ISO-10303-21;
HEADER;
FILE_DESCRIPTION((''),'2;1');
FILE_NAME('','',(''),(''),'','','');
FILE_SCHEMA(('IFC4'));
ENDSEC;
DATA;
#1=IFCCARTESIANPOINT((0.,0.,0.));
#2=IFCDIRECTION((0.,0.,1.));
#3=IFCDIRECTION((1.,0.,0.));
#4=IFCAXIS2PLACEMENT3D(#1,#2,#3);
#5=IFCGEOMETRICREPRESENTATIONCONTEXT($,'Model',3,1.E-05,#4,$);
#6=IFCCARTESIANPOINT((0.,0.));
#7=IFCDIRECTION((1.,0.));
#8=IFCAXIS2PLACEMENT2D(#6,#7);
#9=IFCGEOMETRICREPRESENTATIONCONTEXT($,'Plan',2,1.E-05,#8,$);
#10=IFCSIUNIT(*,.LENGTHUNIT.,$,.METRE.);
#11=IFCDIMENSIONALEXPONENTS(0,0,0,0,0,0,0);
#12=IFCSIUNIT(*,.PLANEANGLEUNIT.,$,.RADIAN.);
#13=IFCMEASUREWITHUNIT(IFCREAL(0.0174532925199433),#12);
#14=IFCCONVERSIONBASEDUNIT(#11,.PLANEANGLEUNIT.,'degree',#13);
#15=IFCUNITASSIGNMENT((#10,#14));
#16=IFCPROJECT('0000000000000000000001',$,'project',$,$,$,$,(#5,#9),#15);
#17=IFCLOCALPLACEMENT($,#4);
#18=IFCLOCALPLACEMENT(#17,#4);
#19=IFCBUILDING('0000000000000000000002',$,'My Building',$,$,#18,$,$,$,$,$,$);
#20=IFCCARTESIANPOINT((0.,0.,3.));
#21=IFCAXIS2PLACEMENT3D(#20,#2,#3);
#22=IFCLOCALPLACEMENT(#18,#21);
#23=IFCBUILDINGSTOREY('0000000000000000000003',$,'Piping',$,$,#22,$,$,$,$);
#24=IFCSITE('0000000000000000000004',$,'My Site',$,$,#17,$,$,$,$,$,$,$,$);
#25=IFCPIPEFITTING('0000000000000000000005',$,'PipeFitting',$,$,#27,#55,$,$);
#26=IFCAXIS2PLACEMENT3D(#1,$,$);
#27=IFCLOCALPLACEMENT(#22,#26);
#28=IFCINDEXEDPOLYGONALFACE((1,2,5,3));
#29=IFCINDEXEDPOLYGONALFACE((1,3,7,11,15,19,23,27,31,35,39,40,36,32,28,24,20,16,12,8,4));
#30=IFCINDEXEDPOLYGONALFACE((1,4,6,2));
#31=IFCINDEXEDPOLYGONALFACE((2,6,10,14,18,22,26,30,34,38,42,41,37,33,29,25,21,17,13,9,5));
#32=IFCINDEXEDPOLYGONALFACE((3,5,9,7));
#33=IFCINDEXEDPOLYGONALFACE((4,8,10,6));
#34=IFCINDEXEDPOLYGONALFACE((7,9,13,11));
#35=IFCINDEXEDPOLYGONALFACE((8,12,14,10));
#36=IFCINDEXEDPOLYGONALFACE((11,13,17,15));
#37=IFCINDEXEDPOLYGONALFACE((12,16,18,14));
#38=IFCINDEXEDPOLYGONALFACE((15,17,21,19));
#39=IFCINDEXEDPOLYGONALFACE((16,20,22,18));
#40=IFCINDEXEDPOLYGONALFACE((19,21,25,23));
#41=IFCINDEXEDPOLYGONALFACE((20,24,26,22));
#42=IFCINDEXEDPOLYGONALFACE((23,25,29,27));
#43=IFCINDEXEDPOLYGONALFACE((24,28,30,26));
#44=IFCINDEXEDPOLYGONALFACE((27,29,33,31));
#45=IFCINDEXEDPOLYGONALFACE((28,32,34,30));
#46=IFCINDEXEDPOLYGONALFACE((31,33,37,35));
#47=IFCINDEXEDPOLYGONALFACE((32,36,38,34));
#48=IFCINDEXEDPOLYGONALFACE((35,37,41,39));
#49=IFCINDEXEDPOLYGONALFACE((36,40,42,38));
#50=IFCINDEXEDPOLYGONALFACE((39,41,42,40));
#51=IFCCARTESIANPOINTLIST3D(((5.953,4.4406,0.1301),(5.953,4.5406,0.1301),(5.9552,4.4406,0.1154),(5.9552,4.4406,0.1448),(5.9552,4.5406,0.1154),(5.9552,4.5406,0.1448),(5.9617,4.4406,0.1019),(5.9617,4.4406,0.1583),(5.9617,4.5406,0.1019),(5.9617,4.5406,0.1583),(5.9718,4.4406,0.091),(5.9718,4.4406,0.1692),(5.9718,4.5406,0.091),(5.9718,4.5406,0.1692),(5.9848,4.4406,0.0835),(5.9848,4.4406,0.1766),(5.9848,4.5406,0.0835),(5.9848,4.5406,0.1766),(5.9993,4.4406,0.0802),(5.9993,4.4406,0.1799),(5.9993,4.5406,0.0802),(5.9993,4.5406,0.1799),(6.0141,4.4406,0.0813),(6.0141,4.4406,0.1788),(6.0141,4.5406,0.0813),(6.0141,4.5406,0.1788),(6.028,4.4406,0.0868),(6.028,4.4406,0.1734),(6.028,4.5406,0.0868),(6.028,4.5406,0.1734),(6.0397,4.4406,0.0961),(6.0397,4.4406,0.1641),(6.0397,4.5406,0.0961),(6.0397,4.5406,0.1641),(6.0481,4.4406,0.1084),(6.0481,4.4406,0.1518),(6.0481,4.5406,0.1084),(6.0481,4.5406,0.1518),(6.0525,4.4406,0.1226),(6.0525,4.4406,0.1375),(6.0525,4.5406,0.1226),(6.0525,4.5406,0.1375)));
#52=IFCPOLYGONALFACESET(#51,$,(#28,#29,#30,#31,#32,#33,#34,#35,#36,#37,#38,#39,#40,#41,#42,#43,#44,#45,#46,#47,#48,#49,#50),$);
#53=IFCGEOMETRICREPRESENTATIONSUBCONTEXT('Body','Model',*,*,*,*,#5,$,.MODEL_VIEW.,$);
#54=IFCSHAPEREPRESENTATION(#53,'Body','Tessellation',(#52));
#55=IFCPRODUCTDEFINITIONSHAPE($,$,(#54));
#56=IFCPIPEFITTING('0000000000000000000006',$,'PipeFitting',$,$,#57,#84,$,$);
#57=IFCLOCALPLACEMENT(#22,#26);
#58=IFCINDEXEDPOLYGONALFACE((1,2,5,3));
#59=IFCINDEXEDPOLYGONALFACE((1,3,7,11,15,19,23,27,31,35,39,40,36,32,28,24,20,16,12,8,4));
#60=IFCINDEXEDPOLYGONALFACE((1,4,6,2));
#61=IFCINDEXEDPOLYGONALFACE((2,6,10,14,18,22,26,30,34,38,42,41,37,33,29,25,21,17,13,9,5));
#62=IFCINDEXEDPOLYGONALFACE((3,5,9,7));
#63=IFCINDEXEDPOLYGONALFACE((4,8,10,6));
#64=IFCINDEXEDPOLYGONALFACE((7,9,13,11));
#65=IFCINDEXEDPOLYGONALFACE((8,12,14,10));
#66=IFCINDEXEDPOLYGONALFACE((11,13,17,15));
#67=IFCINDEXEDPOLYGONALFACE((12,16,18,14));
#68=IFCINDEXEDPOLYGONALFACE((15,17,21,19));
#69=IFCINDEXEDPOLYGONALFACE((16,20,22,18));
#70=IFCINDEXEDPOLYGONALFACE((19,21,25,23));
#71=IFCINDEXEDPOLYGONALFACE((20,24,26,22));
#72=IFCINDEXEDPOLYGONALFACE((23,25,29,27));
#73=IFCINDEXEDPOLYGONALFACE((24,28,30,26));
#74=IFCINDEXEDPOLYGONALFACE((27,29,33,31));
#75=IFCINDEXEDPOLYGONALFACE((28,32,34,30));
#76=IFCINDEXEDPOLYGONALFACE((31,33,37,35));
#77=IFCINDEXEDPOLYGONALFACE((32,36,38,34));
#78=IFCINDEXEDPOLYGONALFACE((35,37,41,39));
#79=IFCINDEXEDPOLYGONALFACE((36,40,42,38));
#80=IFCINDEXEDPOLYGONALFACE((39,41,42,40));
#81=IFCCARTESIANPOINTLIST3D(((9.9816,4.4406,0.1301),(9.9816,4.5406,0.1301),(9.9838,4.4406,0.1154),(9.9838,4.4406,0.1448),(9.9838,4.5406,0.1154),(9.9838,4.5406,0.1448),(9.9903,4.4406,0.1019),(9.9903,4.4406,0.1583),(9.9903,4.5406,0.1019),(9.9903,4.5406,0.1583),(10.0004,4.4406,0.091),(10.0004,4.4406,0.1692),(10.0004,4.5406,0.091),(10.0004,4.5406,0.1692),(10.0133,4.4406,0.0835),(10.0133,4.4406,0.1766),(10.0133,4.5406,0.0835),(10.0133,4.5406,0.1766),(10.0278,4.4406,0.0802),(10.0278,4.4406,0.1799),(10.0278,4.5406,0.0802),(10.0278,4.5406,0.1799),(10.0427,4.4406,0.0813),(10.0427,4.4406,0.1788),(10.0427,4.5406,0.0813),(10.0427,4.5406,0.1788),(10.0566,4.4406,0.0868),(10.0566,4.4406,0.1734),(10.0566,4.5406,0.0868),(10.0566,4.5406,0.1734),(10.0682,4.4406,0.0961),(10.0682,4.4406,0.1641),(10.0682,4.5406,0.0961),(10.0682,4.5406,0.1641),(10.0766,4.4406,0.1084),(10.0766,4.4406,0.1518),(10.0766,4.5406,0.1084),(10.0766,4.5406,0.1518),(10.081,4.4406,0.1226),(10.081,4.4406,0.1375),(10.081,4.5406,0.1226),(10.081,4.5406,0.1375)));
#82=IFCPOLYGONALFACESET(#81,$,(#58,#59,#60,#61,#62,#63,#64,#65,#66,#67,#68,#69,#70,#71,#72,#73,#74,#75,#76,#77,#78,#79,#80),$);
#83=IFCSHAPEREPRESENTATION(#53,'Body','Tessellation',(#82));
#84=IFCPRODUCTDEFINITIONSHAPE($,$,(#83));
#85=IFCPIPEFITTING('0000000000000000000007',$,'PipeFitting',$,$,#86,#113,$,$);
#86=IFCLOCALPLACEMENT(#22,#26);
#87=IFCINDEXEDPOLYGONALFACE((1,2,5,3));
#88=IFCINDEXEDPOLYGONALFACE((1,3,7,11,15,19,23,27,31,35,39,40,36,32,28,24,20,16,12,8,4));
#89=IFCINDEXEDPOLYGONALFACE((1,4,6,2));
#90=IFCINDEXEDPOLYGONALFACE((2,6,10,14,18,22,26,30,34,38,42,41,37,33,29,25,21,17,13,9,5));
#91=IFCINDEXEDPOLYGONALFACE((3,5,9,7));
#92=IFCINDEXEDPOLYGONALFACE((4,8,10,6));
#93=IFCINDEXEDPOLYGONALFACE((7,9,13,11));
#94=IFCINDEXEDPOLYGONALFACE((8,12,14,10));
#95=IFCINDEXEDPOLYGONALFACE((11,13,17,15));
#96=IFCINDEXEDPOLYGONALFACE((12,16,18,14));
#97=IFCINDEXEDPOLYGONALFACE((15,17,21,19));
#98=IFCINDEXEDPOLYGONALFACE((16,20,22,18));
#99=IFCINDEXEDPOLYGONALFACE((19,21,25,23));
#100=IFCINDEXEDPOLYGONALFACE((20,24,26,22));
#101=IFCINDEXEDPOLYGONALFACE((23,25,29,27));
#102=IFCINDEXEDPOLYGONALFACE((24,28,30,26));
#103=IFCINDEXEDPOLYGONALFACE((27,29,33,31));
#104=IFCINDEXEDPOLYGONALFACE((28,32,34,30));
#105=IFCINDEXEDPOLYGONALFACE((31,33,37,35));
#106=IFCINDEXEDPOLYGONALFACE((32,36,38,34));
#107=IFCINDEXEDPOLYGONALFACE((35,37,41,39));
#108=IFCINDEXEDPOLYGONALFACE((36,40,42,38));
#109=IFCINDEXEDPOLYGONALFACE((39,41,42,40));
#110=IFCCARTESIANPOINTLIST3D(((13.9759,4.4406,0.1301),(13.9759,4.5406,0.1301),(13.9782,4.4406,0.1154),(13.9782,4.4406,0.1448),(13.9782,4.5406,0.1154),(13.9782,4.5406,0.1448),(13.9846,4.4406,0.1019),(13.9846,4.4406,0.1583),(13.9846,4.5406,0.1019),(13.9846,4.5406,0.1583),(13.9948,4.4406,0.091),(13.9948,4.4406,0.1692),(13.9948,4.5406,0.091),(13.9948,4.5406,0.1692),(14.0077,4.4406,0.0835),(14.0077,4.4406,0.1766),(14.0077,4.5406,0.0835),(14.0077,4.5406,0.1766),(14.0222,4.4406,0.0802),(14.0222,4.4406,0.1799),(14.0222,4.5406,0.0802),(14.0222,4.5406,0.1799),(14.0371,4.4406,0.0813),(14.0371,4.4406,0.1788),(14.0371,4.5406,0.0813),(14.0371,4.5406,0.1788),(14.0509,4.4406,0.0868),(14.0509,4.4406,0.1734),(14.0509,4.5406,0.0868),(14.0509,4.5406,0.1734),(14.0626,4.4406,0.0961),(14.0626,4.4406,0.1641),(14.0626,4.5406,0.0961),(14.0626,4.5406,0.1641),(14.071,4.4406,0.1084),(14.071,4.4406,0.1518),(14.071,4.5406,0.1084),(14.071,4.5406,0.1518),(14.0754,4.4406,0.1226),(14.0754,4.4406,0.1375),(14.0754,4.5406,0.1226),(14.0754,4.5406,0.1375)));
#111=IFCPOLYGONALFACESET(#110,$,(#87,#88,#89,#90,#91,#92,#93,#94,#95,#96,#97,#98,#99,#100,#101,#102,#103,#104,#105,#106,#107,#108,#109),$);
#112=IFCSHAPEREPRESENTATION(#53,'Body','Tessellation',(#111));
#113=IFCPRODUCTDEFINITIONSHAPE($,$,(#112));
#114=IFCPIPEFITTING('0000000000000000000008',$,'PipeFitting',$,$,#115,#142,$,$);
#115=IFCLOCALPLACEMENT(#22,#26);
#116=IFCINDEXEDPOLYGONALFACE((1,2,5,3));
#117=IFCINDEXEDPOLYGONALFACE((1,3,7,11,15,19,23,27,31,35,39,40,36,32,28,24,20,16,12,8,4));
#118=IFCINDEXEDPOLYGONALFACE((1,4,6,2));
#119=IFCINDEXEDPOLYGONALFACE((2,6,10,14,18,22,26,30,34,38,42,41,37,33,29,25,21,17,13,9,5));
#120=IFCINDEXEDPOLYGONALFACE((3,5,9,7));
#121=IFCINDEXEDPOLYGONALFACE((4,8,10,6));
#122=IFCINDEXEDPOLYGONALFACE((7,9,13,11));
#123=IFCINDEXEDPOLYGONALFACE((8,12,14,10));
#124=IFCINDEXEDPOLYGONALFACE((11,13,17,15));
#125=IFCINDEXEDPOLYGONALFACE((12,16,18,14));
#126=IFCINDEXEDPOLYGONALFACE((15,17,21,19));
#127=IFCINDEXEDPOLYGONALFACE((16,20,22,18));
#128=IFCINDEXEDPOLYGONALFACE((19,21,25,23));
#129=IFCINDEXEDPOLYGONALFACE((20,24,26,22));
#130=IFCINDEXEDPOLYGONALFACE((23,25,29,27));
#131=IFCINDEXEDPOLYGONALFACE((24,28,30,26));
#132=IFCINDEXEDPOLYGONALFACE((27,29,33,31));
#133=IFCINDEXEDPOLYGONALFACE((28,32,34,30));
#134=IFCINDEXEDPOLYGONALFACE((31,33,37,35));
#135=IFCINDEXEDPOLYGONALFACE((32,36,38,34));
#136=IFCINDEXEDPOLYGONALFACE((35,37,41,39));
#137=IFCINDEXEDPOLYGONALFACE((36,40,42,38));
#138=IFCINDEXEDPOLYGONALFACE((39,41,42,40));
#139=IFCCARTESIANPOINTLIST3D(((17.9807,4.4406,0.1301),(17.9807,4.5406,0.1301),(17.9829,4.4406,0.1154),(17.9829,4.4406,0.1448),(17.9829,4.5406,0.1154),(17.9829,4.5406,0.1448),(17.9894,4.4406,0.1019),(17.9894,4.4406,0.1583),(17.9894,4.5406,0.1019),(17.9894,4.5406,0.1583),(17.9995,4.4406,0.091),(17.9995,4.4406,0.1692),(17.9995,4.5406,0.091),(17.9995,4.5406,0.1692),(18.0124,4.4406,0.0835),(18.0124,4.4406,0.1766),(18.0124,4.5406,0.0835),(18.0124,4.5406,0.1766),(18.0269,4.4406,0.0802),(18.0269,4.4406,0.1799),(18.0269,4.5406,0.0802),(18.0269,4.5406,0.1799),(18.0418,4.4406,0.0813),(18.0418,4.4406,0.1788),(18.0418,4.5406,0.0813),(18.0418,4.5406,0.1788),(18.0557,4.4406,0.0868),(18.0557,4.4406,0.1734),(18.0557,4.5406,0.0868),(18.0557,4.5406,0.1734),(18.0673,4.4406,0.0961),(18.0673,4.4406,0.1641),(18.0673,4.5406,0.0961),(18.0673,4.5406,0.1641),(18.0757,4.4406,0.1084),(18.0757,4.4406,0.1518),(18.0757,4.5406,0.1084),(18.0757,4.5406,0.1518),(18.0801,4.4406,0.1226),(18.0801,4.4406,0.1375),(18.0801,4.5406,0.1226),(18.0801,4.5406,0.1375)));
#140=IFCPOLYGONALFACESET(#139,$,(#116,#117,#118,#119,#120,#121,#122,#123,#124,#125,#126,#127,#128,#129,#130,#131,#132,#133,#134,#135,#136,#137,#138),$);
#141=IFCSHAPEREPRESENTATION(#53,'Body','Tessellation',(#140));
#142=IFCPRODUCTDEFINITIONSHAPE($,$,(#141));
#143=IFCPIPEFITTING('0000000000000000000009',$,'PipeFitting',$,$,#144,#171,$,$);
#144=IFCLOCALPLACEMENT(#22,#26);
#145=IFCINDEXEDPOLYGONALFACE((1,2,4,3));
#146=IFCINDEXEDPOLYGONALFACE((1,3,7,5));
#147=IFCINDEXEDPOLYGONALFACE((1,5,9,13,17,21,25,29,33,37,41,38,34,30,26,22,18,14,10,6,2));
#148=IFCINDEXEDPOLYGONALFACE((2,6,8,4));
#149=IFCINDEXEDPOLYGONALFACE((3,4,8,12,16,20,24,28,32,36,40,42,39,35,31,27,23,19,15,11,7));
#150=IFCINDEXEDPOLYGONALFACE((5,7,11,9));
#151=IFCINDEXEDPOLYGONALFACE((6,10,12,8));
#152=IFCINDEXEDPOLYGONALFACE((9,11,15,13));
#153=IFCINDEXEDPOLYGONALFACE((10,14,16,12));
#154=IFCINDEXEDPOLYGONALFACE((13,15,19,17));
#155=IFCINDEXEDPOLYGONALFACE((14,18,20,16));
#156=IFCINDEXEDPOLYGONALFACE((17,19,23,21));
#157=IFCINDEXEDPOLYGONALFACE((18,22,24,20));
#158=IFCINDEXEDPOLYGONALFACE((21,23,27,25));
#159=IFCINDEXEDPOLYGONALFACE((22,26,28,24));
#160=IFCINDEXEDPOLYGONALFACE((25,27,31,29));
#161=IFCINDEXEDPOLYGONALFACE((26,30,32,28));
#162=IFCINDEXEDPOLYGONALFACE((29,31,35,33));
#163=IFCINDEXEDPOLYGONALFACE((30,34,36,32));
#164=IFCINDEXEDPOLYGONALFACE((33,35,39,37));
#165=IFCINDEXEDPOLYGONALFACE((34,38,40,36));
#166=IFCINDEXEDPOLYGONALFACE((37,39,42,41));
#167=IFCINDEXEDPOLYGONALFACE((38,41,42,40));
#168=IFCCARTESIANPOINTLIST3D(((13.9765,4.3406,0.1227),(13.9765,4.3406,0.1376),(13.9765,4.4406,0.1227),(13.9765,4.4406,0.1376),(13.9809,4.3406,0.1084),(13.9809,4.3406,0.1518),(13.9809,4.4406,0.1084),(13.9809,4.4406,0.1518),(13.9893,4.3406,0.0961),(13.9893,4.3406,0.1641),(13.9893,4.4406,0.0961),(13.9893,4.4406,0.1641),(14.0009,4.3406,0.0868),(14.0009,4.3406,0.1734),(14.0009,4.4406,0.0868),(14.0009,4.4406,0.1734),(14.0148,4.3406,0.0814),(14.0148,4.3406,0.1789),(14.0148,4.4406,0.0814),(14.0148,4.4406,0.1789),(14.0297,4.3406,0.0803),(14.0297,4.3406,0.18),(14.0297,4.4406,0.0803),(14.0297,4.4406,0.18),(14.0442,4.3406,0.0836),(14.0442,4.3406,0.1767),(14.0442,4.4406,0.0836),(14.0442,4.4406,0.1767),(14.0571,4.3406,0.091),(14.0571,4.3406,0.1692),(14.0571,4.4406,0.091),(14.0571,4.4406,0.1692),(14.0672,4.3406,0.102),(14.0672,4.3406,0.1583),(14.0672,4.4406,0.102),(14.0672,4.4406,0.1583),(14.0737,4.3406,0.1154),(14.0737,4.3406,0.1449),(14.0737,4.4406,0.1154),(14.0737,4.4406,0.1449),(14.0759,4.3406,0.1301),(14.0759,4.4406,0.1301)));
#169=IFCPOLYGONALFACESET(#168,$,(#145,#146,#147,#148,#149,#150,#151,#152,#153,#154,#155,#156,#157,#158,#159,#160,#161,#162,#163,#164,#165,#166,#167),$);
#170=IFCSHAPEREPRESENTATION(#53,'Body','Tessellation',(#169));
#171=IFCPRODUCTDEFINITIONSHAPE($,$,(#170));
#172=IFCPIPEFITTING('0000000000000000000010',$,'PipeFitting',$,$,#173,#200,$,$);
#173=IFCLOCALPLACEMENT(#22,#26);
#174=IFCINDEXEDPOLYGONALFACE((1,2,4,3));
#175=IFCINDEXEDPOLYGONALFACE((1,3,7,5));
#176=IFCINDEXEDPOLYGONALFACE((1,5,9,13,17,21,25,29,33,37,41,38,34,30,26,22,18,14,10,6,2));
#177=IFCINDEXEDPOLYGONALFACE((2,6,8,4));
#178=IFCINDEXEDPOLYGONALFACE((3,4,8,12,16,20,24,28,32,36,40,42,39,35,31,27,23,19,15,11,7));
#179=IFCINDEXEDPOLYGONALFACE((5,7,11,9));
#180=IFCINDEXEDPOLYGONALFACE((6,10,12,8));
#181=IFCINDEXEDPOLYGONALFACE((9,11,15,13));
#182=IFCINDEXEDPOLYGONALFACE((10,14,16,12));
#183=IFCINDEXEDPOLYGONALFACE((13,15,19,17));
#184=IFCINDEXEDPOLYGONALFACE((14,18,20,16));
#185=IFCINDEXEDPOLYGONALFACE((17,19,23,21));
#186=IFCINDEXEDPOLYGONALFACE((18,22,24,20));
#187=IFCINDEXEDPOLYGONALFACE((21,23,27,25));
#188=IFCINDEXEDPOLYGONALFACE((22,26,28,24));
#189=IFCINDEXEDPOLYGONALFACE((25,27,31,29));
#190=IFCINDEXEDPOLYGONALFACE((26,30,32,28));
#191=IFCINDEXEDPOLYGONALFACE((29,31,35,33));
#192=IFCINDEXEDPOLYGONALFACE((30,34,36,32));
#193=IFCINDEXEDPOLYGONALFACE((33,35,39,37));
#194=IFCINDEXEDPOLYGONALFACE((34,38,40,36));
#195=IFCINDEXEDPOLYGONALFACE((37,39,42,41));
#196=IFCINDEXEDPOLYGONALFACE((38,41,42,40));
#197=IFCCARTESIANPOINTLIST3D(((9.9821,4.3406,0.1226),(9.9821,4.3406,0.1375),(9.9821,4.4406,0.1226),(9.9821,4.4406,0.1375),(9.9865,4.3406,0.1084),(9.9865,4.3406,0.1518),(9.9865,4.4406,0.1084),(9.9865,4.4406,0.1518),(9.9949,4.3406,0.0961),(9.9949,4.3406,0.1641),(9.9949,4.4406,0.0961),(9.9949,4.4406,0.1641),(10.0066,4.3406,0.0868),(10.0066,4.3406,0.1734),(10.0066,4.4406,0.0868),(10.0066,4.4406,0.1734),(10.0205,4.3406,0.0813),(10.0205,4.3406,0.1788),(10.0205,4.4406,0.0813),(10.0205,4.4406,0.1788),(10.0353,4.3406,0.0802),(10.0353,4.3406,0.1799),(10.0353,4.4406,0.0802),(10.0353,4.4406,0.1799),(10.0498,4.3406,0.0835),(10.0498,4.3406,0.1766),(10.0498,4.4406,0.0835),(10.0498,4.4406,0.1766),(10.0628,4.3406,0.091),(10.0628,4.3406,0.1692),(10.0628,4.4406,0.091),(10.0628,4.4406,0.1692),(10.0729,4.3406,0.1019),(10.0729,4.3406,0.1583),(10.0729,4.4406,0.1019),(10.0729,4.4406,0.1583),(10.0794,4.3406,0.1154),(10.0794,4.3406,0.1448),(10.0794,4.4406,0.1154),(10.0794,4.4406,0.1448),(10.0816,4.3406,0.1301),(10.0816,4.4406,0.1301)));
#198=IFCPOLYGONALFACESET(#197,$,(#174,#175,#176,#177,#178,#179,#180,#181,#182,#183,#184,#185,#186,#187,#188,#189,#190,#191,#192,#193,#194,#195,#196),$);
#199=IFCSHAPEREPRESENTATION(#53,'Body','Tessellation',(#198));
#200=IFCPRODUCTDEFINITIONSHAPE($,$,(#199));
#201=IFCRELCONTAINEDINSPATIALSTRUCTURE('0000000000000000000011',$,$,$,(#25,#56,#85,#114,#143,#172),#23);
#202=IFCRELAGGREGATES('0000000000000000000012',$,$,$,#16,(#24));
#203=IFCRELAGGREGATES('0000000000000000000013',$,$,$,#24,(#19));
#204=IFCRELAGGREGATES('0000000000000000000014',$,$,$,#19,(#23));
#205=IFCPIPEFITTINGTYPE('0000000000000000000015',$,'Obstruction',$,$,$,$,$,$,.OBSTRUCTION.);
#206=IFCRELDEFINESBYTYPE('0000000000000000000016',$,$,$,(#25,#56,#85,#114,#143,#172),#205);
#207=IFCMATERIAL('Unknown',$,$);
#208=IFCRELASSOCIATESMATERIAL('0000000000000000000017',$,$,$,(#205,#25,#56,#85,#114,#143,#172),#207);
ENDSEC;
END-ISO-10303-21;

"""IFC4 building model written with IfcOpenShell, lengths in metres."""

from ifc_helpers import new_model, entity, si_unit, converted_unit, frame, origin_with_axes, origin_2d_with_axis, place, context, subcontext, project, spatial, circle, extrude, material, material_profile, profile_set, profile_usage, type_object, element, save


model = new_model("IFC4")

# Units and contexts
model_context = context("Model", 3, precision=1e-05, world=origin_with_axes())
plan_context = context("Plan", 2, precision=1e-05, world=origin_2d_with_axis())
body_context = subcontext(model_context, "Body", "Model", "MODEL_VIEW")
ifc_project = project(units=[si_unit("LENGTHUNIT", "METRE"), converted_unit("PLANEANGLEUNIT", "degree", entity("IfcReal", 0.0174532925199433), si_unit("PLANEANGLEUNIT", "RADIAN"), dimensions=[0, 0, 0, 0, 0, 0, 0])], contexts=[model_context, plan_context])

# Site, building, storey
site_placement = place(None, origin_with_axes())
site = spatial("IfcSite", under=ifc_project, at=site_placement, Name="My Site")
building_placement = place(site_placement, origin_with_axes())
building = spatial("IfcBuilding", under=site, at=building_placement, Name="My Building")
storey_placement = place(building_placement, frame((0.0, 0.0, 3.0), z_axis=(0.0, 0.0, 1.0), x_axis=(1.0, 0.0, 0.0)))
storey = spatial("IfcBuildingStorey", under=building, at=storey_placement, Name="Piping")

# Shared definitions
ifc_material = material(Name="Unknown")

# Pipe fittings
ifc_material_profile_1 = material_profile(ifc_material, circle(Radius=0.05))
ifc_profile_set_1 = profile_set([ifc_material_profile_1])
ifc_profile_usage_1 = profile_usage(ifc_profile_set_1, cardinal=5)
pipe_fitting_type_1 = type_object("IfcPipeFittingType", Name="Obstruction", PredefinedType="OBSTRUCTION", material=ifc_profile_set_1)
pipe_fitting_1_placement = place(storey_placement, frame((6.003, 4.4406, 0.1301), z_axis=(0.0, 1.0, -0.000001), x_axis=(-1.0, 0.0, 0.0)))
element("IfcPipeFitting", 1, at=pipe_fitting_1_placement, inside=storey, type_object=pipe_fitting_type_1, material=ifc_profile_usage_1, Name="PipeFitting", context=body_context, shape_type="SweptSolid", body=[
    extrude(circle(Radius=0.05), origin_with_axes(), (0.0, 0.0, 1.0), 0.1),
])
ifc_profile_usage_2 = profile_usage(ifc_profile_set_1, cardinal=5)
pipe_fitting_2_placement = place(storey_placement, frame((10.0316, 4.4406, 0.1301), z_axis=(0.0, 1.0, -0.000001), x_axis=(-1.0, 0.0, 0.0)))
element("IfcPipeFitting", 2, at=pipe_fitting_2_placement, inside=storey, type_object=pipe_fitting_type_1, material=ifc_profile_usage_2, Name="PipeFitting", context=body_context, shape_type="SweptSolid", body=[
    extrude(circle(Radius=0.05), origin_with_axes(), (0.0, 0.0, 1.0), 0.1),
])
ifc_profile_usage_3 = profile_usage(ifc_profile_set_1, cardinal=5)
pipe_fitting_3_placement = place(storey_placement, frame((14.0259, 4.4406, 0.1301), z_axis=(0.0, 1.0, -0.000001), x_axis=(-1.0, 0.0, 0.0)))
element("IfcPipeFitting", 3, at=pipe_fitting_3_placement, inside=storey, type_object=pipe_fitting_type_1, material=ifc_profile_usage_3, Name="PipeFitting", context=body_context, shape_type="SweptSolid", body=[
    extrude(circle(Radius=0.05), origin_with_axes(), (0.0, 0.0, 1.0), 0.1),
])
ifc_profile_usage_4 = profile_usage(ifc_profile_set_1, cardinal=5)
pipe_fitting_4_placement = place(storey_placement, frame((18.0307, 4.4406, 0.1301), z_axis=(0.0, 1.0, -0.000001), x_axis=(-1.0, 0.0, 0.0)))
element("IfcPipeFitting", 4, at=pipe_fitting_4_placement, inside=storey, type_object=pipe_fitting_type_1, material=ifc_profile_usage_4, Name="PipeFitting", context=body_context, shape_type="SweptSolid", body=[
    extrude(circle(Radius=0.05), origin_with_axes(), (0.0, 0.0, 1.0), 0.1),
])
ifc_profile_usage_5 = profile_usage(ifc_profile_set_1, cardinal=5)
pipe_fitting_5_placement = place(storey_placement, frame((14.0259, 4.4406, 0.1301), z_axis=(0.0, -1.0, 0.000015), x_axis=(1.0, 0.0, 0.0)))
element("IfcPipeFitting", 5, at=pipe_fitting_5_placement, inside=storey, type_object=pipe_fitting_type_1, material=ifc_profile_usage_5, Name="PipeFitting", context=body_context, shape_type="SweptSolid", body=[
    extrude(circle(Radius=0.05), origin_with_axes(), (0.0, 0.0, 1.0), 0.1),
])
ifc_profile_usage_6 = profile_usage(ifc_profile_set_1, cardinal=5)
pipe_fitting_6_placement = place(storey_placement, frame((10.0316, 4.4406, 0.1301), z_axis=(0.0, -1.0, 0.000015), x_axis=(1.0, 0.0, 0.0)))
element("IfcPipeFitting", 6, at=pipe_fitting_6_placement, inside=storey, type_object=pipe_fitting_type_1, material=ifc_profile_usage_6, Name="PipeFitting", context=body_context, shape_type="SweptSolid", body=[
    extrude(circle(Radius=0.05), origin_with_axes(), (0.0, 0.0, 1.0), 0.1),
])

save(model, "model.ifc")
